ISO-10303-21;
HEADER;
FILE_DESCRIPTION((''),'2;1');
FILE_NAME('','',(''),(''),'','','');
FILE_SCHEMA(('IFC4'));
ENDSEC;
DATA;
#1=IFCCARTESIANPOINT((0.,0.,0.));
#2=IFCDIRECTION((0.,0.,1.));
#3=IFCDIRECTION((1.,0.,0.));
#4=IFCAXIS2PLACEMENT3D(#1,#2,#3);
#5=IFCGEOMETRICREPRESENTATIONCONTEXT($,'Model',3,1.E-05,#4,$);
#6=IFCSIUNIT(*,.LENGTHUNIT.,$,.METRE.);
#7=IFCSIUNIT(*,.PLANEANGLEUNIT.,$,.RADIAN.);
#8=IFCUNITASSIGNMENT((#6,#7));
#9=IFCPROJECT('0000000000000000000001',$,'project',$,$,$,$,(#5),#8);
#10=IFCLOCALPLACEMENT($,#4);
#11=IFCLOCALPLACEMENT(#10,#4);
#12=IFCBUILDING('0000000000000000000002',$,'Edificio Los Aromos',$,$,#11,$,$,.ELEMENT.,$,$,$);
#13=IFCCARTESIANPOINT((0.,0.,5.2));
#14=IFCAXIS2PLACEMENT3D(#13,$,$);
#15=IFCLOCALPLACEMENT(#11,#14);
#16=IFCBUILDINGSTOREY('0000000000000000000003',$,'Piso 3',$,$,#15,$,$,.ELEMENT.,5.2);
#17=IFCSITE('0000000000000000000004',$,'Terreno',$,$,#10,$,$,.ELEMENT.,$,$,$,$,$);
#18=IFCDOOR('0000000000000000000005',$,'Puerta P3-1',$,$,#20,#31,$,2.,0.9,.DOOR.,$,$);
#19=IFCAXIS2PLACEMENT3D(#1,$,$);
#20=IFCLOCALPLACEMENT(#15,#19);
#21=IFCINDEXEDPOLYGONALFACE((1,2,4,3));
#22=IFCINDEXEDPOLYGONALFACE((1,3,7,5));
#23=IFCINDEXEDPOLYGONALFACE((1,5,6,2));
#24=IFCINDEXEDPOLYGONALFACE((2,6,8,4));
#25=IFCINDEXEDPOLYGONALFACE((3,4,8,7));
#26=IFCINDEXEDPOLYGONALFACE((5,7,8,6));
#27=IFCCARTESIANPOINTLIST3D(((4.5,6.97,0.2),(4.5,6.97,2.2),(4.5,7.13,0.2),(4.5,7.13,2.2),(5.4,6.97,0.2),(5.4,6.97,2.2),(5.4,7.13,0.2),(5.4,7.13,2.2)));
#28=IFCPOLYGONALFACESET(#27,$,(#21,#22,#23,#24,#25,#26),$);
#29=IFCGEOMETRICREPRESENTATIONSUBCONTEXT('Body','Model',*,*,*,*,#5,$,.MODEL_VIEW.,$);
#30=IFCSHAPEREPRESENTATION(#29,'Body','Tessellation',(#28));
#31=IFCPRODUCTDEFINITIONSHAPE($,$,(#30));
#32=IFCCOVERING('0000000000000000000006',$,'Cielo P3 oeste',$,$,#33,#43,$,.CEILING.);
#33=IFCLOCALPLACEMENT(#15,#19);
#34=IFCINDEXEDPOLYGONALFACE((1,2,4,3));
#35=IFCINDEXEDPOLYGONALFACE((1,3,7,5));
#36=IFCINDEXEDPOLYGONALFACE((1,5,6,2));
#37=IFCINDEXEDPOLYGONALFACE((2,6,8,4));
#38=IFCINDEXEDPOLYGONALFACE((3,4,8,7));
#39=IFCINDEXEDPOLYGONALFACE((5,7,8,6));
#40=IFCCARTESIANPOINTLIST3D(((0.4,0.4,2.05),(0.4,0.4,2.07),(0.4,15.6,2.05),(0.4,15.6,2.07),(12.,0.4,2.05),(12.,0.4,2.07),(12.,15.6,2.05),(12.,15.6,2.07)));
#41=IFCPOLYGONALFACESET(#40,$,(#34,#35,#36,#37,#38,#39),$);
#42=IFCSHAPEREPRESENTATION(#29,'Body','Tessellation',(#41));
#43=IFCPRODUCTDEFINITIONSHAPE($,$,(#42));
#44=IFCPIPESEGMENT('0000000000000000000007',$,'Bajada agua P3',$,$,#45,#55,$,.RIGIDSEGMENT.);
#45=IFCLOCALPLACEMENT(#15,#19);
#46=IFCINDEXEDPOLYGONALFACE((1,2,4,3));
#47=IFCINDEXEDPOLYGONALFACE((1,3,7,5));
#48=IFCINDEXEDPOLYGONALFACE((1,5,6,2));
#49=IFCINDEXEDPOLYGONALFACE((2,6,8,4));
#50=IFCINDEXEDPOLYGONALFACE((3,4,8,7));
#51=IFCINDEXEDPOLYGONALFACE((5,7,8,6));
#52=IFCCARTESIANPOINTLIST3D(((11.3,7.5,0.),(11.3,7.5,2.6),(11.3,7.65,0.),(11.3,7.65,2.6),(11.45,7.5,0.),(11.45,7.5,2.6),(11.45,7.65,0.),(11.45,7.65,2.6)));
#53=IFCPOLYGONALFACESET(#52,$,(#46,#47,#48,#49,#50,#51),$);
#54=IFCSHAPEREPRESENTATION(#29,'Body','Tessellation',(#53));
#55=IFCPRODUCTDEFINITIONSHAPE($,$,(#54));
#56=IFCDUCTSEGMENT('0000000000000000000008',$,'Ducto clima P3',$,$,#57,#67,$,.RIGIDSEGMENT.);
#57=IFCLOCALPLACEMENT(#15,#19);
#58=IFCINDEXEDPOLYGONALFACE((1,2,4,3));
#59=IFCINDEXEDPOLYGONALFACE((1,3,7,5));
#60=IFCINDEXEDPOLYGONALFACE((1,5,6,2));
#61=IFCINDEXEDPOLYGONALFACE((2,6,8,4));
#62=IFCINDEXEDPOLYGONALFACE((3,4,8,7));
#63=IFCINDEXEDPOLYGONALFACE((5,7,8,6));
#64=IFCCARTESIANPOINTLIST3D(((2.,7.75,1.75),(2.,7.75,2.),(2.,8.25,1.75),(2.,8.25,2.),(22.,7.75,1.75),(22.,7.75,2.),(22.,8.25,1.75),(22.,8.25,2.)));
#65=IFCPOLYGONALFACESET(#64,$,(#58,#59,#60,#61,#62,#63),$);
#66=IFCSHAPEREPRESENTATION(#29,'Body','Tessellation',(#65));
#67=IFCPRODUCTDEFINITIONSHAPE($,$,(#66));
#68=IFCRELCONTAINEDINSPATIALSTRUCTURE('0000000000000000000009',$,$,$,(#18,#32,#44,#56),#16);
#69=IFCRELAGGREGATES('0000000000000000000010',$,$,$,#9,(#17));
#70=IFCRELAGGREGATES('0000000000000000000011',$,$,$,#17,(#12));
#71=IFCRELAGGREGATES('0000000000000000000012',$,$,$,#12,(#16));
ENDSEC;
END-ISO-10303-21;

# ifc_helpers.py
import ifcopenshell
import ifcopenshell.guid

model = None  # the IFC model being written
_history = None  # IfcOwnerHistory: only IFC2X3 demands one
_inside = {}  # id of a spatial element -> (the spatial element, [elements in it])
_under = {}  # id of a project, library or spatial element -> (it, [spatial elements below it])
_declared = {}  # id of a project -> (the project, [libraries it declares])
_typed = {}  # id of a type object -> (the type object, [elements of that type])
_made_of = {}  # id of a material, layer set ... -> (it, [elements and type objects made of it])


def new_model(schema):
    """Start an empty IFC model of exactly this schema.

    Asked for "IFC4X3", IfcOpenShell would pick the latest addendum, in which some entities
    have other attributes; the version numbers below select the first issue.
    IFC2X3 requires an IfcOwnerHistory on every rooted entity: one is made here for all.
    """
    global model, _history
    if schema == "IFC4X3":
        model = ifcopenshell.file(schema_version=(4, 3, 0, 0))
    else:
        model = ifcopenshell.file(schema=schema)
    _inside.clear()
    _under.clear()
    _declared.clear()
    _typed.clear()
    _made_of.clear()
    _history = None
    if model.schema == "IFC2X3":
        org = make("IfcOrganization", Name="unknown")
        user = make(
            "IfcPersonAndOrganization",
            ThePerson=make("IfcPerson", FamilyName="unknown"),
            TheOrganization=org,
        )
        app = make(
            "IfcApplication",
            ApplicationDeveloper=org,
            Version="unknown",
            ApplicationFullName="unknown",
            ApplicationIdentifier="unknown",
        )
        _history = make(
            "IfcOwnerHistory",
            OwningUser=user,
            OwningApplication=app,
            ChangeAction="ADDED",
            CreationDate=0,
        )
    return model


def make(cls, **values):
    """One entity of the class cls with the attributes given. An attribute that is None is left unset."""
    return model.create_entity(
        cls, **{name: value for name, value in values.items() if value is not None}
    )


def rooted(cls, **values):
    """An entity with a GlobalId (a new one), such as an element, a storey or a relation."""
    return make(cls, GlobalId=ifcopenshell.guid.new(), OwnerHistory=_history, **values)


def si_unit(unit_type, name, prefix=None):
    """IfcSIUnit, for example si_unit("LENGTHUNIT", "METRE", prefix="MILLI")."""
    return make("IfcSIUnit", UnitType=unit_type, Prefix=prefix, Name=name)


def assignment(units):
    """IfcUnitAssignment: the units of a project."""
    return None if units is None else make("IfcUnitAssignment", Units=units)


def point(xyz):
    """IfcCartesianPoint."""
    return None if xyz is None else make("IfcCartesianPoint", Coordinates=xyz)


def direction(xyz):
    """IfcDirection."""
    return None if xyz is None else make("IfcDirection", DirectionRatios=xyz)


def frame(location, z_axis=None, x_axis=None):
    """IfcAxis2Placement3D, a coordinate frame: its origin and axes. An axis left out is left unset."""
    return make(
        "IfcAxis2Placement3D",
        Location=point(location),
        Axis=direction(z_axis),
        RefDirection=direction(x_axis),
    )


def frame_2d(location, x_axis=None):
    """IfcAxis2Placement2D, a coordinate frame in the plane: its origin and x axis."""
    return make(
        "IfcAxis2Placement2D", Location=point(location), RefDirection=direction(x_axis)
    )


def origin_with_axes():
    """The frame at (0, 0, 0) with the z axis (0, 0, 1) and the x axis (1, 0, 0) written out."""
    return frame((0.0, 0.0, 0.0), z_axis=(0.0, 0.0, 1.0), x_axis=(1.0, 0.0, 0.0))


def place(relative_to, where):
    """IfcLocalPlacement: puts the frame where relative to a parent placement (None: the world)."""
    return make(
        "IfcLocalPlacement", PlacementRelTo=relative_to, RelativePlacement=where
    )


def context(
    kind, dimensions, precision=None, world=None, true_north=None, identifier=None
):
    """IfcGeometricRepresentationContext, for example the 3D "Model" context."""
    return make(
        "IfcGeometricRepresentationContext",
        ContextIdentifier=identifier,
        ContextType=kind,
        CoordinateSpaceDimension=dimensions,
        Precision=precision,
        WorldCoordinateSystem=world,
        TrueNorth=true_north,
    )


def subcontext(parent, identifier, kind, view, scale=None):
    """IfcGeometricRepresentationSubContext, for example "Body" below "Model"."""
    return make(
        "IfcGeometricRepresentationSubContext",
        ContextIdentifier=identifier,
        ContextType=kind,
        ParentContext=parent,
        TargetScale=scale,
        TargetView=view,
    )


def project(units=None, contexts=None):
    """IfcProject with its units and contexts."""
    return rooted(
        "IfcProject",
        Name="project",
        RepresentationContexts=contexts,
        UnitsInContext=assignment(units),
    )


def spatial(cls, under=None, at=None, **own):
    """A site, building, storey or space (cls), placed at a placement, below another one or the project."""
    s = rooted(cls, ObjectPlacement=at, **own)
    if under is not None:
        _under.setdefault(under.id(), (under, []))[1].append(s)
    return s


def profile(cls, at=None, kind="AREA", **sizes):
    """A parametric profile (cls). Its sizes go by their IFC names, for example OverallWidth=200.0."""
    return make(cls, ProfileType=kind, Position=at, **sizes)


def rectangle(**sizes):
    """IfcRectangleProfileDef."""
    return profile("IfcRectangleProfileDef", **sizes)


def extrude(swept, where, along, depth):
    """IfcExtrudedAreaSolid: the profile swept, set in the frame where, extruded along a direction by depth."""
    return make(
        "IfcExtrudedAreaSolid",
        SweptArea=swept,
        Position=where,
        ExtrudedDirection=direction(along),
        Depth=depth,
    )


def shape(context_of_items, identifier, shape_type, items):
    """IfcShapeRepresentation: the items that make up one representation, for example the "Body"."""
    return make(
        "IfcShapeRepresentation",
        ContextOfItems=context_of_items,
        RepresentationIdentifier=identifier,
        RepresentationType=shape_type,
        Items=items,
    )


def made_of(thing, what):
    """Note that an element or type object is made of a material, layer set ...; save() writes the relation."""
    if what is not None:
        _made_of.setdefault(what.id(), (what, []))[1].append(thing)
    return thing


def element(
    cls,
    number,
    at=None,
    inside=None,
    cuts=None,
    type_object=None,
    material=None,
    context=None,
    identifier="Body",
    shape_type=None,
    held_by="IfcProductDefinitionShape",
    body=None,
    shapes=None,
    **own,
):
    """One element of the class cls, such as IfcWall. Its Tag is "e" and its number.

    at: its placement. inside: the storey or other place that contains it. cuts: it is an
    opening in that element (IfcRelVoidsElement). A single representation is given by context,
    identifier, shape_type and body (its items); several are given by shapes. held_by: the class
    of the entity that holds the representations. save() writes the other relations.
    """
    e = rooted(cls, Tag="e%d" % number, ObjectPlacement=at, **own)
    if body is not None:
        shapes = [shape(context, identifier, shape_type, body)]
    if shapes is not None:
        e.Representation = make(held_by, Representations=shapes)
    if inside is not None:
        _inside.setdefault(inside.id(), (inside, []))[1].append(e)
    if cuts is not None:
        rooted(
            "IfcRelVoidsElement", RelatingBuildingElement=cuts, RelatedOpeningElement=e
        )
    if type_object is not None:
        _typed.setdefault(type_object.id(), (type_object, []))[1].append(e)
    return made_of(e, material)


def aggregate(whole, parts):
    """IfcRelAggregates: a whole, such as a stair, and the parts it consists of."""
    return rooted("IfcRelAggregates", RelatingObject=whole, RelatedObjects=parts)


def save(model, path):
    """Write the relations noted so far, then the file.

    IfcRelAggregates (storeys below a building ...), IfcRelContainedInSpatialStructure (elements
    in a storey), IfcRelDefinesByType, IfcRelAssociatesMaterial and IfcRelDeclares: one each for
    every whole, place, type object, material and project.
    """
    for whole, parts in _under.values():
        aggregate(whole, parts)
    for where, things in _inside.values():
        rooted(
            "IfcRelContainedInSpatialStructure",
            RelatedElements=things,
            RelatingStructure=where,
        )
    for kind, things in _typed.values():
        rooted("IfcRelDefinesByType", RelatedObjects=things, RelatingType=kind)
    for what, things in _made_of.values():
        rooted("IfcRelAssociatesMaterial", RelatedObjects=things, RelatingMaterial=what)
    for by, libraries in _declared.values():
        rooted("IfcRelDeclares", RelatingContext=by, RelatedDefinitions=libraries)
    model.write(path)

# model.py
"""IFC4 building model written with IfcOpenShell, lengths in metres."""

from ifc_helpers import new_model, si_unit, frame, frame_2d, origin_with_axes, place, context, subcontext, project, spatial, rectangle, extrude, element, save


model = new_model("IFC4")

# Units and contexts
model_context = context("Model", 3, precision=1e-05, world=origin_with_axes())
body_context = subcontext(model_context, "Body", "Model", "MODEL_VIEW")
ifc_project = project(units=[si_unit("LENGTHUNIT", "METRE"), si_unit("PLANEANGLEUNIT", "RADIAN")], contexts=[model_context])

# Site, building, storey
site_placement = place(None, origin_with_axes())
site = spatial("IfcSite", under=ifc_project, at=site_placement, Name="Terreno", CompositionType="ELEMENT")
building_placement = place(site_placement, origin_with_axes())
building = spatial("IfcBuilding", under=site, at=building_placement, Name="Edificio Los Aromos", CompositionType="ELEMENT")
storey_placement = place(building_placement, frame((0.0, 0.0, 5.2)))
storey = spatial("IfcBuildingStorey", under=building, at=storey_placement, Name="Piso 3", CompositionType="ELEMENT", Elevation=5.2)

# Door
door_placement = place(storey_placement, frame((4.5, 6.97, 0.2)))
element("IfcDoor", 1, at=door_placement, inside=storey, Name="Puerta P3-1", OverallHeight=2.0, OverallWidth=0.9, PredefinedType="DOOR", context=body_context, shape_type="SweptSolid", body=[
    extrude(rectangle(XDim=0.9, YDim=0.16, at=frame_2d((0.45, 0.08))), origin_with_axes(), (0.0, 0.0, 1.0), 2.0),
])

# Covering
covering_placement = place(storey_placement, frame((0.4, 0.4, 2.05)))
element("IfcCovering", 2, at=covering_placement, inside=storey, Name="Cielo P3 oeste", PredefinedType="CEILING", context=body_context, shape_type="SweptSolid", body=[
    extrude(rectangle(XDim=11.6, YDim=15.2, at=frame_2d((5.8, 7.6))), origin_with_axes(), (0.0, 0.0, 1.0), 0.02),
])

# Pipe segment
pipe_segment_placement = place(storey_placement, frame((11.3, 7.5, 0.0)))
element("IfcPipeSegment", 3, at=pipe_segment_placement, inside=storey, Name="Bajada agua P3", PredefinedType="RIGIDSEGMENT", context=body_context, shape_type="SweptSolid", body=[
    extrude(rectangle(XDim=0.15, YDim=0.15, at=frame_2d((0.075, 0.075))), origin_with_axes(), (0.0, 0.0, 1.0), 2.6),
])

# Duct segment
duct_segment_placement = place(storey_placement, frame((2.0, 7.75, 1.75)))
element("IfcDuctSegment", 4, at=duct_segment_placement, inside=storey, Name="Ducto clima P3", PredefinedType="RIGIDSEGMENT", context=body_context, shape_type="SweptSolid", body=[
    extrude(rectangle(XDim=20.0, YDim=0.5, at=frame_2d((10.0, 0.25))), origin_with_axes(), (0.0, 0.0, 1.0), 0.25),
])

save(model, "model.ifc")
